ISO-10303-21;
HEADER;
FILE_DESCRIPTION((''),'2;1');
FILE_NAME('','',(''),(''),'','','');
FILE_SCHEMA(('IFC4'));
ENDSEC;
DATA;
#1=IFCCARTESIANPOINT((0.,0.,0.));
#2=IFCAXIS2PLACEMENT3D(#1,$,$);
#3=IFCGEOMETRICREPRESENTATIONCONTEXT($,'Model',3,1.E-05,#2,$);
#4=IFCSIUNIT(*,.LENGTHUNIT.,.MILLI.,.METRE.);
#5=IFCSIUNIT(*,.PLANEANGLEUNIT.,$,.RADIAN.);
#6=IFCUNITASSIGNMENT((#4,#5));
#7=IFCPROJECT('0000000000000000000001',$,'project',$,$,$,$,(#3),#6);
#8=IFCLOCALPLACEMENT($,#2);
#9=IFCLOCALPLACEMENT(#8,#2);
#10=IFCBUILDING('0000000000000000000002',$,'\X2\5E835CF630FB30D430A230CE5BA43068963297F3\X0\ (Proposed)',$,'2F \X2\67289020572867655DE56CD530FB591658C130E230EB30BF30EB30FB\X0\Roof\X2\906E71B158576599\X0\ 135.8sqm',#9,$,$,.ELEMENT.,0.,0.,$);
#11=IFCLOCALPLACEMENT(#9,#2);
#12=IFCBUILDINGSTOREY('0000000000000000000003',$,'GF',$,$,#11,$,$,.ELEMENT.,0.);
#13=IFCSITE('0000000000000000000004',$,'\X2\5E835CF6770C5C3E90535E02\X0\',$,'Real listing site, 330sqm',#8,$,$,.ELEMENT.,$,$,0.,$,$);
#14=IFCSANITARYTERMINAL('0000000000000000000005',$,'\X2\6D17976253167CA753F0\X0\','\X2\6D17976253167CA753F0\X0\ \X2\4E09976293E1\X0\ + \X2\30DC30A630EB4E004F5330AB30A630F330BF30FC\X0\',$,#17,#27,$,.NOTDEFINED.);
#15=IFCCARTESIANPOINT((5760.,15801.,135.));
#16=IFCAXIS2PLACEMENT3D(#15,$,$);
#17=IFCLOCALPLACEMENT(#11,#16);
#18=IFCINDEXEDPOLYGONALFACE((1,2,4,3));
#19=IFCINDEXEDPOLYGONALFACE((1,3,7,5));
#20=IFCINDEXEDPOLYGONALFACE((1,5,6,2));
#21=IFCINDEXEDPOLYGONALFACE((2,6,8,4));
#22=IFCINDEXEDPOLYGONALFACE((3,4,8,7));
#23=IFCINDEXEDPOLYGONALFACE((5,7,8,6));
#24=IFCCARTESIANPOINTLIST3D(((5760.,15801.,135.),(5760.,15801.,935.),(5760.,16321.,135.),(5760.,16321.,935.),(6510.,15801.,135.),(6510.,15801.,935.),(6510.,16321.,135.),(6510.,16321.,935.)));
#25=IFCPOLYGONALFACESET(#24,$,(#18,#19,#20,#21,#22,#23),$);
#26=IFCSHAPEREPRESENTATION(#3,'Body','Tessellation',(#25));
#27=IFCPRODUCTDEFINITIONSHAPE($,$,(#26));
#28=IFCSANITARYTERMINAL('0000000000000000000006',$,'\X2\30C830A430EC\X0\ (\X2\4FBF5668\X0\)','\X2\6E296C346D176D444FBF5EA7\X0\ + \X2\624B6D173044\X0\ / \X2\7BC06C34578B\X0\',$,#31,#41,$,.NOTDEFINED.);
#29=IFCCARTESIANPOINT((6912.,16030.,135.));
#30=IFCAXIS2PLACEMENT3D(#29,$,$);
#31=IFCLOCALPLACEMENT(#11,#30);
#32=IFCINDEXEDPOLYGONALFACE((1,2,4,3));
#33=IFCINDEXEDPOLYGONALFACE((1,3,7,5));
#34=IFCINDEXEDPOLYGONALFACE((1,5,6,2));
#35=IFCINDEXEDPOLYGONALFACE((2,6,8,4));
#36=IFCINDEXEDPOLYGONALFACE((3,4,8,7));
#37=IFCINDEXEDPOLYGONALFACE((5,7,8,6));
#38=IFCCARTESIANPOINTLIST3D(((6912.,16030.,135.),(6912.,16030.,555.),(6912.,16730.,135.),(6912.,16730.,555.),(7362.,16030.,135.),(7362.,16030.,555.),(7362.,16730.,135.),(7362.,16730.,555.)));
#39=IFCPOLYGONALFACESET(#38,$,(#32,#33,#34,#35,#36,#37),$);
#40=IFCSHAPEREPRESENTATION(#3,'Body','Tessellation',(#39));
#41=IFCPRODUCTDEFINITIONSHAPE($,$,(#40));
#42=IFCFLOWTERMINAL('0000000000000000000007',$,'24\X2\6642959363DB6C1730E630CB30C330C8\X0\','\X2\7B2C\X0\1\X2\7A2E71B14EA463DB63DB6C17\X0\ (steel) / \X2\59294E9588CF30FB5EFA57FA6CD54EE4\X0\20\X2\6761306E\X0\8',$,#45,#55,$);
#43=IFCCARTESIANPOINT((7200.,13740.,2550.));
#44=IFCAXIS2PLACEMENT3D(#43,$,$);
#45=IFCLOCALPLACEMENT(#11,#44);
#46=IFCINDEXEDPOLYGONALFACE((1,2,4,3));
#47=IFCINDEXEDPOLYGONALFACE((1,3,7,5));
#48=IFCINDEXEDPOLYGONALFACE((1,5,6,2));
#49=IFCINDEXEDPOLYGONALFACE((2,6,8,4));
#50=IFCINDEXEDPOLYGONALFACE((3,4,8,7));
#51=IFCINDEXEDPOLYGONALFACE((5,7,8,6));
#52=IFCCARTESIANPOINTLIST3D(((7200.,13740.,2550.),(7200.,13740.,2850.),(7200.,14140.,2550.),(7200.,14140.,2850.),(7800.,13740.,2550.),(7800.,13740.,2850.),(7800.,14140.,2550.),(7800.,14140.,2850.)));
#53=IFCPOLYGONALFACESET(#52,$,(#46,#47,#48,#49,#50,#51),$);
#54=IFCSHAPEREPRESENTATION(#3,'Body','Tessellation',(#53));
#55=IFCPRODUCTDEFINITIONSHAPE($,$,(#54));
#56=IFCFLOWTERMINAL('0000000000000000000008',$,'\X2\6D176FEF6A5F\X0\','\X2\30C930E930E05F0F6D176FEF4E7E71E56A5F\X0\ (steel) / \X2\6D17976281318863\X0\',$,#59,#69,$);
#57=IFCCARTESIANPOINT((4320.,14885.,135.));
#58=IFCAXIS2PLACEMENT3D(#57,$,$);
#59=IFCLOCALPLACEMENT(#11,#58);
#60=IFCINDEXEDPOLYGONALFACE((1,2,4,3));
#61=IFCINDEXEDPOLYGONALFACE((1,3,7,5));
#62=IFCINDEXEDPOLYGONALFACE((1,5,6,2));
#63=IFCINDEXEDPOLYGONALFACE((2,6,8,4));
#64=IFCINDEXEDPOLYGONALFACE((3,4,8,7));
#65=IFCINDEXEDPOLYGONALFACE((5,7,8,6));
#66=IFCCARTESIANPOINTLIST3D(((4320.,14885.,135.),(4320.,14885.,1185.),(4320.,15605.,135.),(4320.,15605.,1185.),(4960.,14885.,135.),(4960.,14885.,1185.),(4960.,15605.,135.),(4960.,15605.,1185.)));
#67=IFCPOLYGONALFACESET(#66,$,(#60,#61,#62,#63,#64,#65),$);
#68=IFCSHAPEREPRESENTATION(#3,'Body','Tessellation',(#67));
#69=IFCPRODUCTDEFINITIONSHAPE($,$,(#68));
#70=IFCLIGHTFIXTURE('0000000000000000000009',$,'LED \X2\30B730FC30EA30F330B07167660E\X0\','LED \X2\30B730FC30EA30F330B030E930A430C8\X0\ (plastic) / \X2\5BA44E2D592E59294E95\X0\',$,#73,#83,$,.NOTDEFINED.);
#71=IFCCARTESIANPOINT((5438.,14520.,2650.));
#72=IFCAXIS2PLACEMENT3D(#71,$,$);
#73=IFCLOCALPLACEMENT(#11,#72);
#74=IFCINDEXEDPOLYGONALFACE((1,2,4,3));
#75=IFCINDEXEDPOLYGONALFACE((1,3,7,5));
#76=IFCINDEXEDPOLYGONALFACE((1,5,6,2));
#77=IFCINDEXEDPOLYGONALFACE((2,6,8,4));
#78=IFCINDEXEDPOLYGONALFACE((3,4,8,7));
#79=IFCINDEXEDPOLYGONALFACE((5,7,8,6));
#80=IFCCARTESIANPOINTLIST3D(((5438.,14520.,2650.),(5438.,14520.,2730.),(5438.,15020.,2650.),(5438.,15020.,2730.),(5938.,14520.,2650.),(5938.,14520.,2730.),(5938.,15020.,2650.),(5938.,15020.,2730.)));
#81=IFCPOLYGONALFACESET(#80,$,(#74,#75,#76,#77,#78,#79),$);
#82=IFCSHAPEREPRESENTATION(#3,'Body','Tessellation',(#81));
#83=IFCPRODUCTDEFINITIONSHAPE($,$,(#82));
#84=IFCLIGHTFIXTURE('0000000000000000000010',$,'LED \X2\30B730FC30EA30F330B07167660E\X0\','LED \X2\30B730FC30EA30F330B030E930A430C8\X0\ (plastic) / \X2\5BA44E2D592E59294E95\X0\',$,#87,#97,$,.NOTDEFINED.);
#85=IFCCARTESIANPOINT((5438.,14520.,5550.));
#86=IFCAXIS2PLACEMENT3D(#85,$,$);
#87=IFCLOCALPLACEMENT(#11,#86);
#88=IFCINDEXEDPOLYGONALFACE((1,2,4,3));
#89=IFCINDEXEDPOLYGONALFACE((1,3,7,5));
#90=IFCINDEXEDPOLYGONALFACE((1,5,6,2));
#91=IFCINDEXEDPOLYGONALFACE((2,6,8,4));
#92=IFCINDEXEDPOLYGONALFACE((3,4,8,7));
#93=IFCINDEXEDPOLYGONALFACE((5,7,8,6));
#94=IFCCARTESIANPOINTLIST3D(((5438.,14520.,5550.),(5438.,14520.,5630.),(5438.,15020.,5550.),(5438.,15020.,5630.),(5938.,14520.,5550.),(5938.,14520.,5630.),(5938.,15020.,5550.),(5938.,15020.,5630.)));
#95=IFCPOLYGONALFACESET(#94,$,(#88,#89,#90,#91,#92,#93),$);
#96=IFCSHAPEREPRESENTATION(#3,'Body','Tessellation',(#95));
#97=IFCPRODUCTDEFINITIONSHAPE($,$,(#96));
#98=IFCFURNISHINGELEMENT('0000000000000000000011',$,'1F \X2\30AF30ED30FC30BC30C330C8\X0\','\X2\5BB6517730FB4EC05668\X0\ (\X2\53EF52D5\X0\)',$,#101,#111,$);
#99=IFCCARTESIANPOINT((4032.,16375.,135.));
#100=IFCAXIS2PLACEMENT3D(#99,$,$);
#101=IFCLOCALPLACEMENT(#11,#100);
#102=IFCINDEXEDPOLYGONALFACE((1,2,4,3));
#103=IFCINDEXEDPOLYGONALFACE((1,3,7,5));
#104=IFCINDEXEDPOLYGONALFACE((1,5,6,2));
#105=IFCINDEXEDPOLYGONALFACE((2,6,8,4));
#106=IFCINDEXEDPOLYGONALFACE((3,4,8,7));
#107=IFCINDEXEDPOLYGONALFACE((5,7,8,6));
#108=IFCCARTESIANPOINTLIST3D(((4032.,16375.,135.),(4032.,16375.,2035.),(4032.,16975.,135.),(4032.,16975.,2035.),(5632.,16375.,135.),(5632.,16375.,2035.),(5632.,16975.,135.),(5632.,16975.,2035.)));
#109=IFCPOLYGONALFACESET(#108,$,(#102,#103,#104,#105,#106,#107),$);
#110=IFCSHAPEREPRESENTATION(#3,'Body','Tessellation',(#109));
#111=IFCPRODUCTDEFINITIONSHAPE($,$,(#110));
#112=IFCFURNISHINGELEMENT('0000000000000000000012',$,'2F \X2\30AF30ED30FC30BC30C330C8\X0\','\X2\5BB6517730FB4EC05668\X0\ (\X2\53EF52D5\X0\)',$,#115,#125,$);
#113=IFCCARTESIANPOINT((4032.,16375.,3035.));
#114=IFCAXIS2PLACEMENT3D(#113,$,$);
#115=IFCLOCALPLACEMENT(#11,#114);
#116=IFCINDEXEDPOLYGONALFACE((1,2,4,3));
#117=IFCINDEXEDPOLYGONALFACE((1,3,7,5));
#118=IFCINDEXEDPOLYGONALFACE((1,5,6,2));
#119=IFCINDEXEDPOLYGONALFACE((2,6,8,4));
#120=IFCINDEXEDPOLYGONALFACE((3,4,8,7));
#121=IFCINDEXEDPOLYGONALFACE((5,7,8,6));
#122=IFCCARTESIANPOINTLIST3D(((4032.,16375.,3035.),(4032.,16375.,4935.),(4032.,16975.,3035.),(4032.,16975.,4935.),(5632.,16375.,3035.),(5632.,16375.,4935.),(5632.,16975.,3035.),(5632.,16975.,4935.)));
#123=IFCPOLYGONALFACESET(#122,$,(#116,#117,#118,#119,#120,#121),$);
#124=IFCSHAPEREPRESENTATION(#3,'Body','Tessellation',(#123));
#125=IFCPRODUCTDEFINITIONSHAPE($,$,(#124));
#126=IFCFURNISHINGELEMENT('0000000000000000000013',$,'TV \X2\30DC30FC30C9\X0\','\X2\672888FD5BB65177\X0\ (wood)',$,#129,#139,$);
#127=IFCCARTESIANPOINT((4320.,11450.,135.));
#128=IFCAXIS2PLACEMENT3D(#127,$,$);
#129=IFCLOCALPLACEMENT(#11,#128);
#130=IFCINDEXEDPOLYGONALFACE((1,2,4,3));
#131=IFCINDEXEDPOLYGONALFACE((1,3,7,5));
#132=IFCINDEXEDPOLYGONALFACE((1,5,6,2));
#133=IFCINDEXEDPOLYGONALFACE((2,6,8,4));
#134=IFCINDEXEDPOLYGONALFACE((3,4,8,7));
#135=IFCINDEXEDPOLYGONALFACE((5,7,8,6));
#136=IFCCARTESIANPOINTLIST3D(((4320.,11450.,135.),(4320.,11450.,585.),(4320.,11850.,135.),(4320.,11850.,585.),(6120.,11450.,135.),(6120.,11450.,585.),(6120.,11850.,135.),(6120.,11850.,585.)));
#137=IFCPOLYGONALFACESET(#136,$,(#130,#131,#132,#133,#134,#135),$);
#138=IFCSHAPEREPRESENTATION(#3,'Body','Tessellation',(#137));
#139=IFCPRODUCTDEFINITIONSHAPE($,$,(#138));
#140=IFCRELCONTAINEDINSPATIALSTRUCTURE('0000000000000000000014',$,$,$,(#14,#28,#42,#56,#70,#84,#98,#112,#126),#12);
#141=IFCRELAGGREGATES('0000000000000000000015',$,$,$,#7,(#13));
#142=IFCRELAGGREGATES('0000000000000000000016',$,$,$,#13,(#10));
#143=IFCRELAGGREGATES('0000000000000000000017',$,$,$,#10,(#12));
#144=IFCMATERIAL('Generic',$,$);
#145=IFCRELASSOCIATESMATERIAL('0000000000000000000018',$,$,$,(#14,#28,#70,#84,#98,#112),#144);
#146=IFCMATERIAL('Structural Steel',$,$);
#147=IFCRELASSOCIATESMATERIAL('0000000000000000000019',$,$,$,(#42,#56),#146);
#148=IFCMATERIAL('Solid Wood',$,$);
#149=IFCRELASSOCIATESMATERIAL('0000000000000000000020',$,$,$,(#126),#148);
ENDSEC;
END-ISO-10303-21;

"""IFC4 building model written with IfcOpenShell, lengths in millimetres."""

from ifc_helpers import new_model, si_unit, frame, frame_2d, origin, place, context, project, spatial, rectangle, extrude, material, element, save


model = new_model("IFC4")

# Units and contexts
model_context = context("Model", 3, precision=1e-05, world=origin())
ifc_project = project(units=[si_unit("LENGTHUNIT", "METRE", prefix="MILLI"), si_unit("PLANEANGLEUNIT", "RADIAN")], contexts=[model_context])

# Site, building, storey
site_placement = place(None, origin())
site = spatial("IfcSite", under=ifc_project, at=site_placement, Name="広島県尾道市", ObjectType="Real listing site, 330sqm", CompositionType="ELEMENT", RefElevation=0.0)
building_placement = place(site_placement, origin())
building = spatial("IfcBuilding", under=site, at=building_placement, Name="広島・ピアノ室と防音 (Proposed)", ObjectType="2F 木造在来工法・外壁モルタル・Roof遮熱塗料 135.8sqm", CompositionType="ELEMENT", ElevationOfRefHeight=0.0, ElevationOfTerrain=0.0)
storey_placement = place(building_placement, origin())
storey = spatial("IfcBuildingStorey", under=building, at=storey_placement, Name="GF", CompositionType="ELEMENT", Elevation=0.0)

# Shared definitions
ifc_material_1 = material(Name="Solid Wood")

# Sanitary terminals
ifc_material_2 = material(Name="Generic")
sanitary_terminal_1_placement = place(storey_placement, frame((5760.0, 15801.0, 135.0)))
element("IfcSanitaryTerminal", 1, at=sanitary_terminal_1_placement, inside=storey, material=ifc_material_2, Name="洗面化粧台", Description="洗面化粧台 三面鏡 + ボウル一体カウンター", PredefinedType="NOTDEFINED", context=model_context, shape_type="SweptSolid", body=[
    extrude(rectangle(XDim=750.0, YDim=520.0, at=frame_2d((375.0, 260.0))), frame((5760.0, 15801.0, 135.0)), (0.0, 0.0, 1.0), 800.0),
])
sanitary_terminal_2_placement = place(storey_placement, frame((6912.0, 16030.0, 135.0)))
element("IfcSanitaryTerminal", 2, at=sanitary_terminal_2_placement, inside=storey, material=ifc_material_2, Name="トイレ (便器)", Description="温水洗浄便座 + 手洗い / 節水型", PredefinedType="NOTDEFINED", context=model_context, shape_type="SweptSolid", body=[
    extrude(rectangle(XDim=450.0, YDim=700.0, at=frame_2d((225.0, 350.0))), frame((6912.0, 16030.0, 135.0)), (0.0, 0.0, 1.0), 420.0),
])

# Flow terminals
ifc_material_3 = material(Name="Structural Steel")
flow_terminal_1_placement = place(storey_placement, frame((7200.0, 13740.0, 2550.0)))
element("IfcFlowTerminal", 3, at=flow_terminal_1_placement, inside=storey, material=ifc_material_3, Name="24時間換気ユニット", Description="第1種熱交換換気 (steel) / 天井裏・建基法令20条の8", context=model_context, shape_type="SweptSolid", body=[
    extrude(rectangle(XDim=600.0, YDim=400.0, at=frame_2d((300.0, 200.0))), frame((7200.0, 13740.0, 2550.0)), (0.0, 0.0, 1.0), 300.0),
])
flow_terminal_2_placement = place(storey_placement, frame((4320.0, 14885.0, 135.0)))
element("IfcFlowTerminal", 4, at=flow_terminal_2_placement, inside=storey, material=ifc_material_3, Name="洗濯機", Description="ドラム式洗濯乾燥機 (steel) / 洗面脱衣", context=model_context, shape_type="SweptSolid", body=[
    extrude(rectangle(XDim=640.0, YDim=720.0, at=frame_2d((320.0, 360.0))), frame((4320.0, 14885.0, 135.0)), (0.0, 0.0, 1.0), 1050.0),
])

# Light fixtures
light_fixture_1_placement = place(storey_placement, frame((5438.0, 14520.0, 2650.0)))
element("IfcLightFixture", 5, at=light_fixture_1_placement, inside=storey, material=ifc_material_2, Name="LED シーリング照明", Description="LED シーリングライト (plastic) / 室中央天井", PredefinedType="NOTDEFINED", context=model_context, shape_type="SweptSolid", body=[
    extrude(rectangle(XDim=500.0, YDim=500.0, at=frame_2d((250.0, 250.0))), frame((5438.0, 14520.0, 2650.0)), (0.0, 0.0, 1.0), 80.0),
])
light_fixture_2_placement = place(storey_placement, frame((5438.0, 14520.0, 5550.0)))
element("IfcLightFixture", 6, at=light_fixture_2_placement, inside=storey, material=ifc_material_2, Name="LED シーリング照明", Description="LED シーリングライト (plastic) / 室中央天井", PredefinedType="NOTDEFINED", context=model_context, shape_type="SweptSolid", body=[
    extrude(rectangle(XDim=500.0, YDim=500.0, at=frame_2d((250.0, 250.0))), frame((5438.0, 14520.0, 5550.0)), (0.0, 0.0, 1.0), 80.0),
])

# Furnishing elements
furnishing_1_placement = place(storey_placement, frame((4032.0, 16375.0, 135.0)))
element("IfcFurnishingElement", 7, at=furnishing_1_placement, inside=storey, material=ifc_material_2, Name="1F クローゼット", Description="家具・什器 (可動)", context=model_context, shape_type="SweptSolid", body=[
    extrude(rectangle(XDim=1600.0, YDim=600.0, at=frame_2d((800.0, 300.0))), frame((4032.0, 16375.0, 135.0)), (0.0, 0.0, 1.0), 1900.0),
])
furnishing_2_placement = place(storey_placement, frame((4032.0, 16375.0, 3035.0)))
element("IfcFurnishingElement", 8, at=furnishing_2_placement, inside=storey, material=ifc_material_2, Name="2F クローゼット", Description="家具・什器 (可動)", context=model_context, shape_type="SweptSolid", body=[
    extrude(rectangle(XDim=1600.0, YDim=600.0, at=frame_2d((800.0, 300.0))), frame((4032.0, 16375.0, 3035.0)), (0.0, 0.0, 1.0), 1900.0),
])
furnishing_3_placement = place(storey_placement, frame((4320.0, 11450.0, 135.0)))
element("IfcFurnishingElement", 9, at=furnishing_3_placement, inside=storey, material=ifc_material_1, Name="TV ボード", Description="木製家具 (wood)", context=model_context, shape_type="SweptSolid", body=[
    extrude(rectangle(XDim=1800.0, YDim=400.0, at=frame_2d((900.0, 200.0))), frame((4320.0, 11450.0, 135.0)), (0.0, 0.0, 1.0), 450.0),
])

save(model, "model.ifc")
